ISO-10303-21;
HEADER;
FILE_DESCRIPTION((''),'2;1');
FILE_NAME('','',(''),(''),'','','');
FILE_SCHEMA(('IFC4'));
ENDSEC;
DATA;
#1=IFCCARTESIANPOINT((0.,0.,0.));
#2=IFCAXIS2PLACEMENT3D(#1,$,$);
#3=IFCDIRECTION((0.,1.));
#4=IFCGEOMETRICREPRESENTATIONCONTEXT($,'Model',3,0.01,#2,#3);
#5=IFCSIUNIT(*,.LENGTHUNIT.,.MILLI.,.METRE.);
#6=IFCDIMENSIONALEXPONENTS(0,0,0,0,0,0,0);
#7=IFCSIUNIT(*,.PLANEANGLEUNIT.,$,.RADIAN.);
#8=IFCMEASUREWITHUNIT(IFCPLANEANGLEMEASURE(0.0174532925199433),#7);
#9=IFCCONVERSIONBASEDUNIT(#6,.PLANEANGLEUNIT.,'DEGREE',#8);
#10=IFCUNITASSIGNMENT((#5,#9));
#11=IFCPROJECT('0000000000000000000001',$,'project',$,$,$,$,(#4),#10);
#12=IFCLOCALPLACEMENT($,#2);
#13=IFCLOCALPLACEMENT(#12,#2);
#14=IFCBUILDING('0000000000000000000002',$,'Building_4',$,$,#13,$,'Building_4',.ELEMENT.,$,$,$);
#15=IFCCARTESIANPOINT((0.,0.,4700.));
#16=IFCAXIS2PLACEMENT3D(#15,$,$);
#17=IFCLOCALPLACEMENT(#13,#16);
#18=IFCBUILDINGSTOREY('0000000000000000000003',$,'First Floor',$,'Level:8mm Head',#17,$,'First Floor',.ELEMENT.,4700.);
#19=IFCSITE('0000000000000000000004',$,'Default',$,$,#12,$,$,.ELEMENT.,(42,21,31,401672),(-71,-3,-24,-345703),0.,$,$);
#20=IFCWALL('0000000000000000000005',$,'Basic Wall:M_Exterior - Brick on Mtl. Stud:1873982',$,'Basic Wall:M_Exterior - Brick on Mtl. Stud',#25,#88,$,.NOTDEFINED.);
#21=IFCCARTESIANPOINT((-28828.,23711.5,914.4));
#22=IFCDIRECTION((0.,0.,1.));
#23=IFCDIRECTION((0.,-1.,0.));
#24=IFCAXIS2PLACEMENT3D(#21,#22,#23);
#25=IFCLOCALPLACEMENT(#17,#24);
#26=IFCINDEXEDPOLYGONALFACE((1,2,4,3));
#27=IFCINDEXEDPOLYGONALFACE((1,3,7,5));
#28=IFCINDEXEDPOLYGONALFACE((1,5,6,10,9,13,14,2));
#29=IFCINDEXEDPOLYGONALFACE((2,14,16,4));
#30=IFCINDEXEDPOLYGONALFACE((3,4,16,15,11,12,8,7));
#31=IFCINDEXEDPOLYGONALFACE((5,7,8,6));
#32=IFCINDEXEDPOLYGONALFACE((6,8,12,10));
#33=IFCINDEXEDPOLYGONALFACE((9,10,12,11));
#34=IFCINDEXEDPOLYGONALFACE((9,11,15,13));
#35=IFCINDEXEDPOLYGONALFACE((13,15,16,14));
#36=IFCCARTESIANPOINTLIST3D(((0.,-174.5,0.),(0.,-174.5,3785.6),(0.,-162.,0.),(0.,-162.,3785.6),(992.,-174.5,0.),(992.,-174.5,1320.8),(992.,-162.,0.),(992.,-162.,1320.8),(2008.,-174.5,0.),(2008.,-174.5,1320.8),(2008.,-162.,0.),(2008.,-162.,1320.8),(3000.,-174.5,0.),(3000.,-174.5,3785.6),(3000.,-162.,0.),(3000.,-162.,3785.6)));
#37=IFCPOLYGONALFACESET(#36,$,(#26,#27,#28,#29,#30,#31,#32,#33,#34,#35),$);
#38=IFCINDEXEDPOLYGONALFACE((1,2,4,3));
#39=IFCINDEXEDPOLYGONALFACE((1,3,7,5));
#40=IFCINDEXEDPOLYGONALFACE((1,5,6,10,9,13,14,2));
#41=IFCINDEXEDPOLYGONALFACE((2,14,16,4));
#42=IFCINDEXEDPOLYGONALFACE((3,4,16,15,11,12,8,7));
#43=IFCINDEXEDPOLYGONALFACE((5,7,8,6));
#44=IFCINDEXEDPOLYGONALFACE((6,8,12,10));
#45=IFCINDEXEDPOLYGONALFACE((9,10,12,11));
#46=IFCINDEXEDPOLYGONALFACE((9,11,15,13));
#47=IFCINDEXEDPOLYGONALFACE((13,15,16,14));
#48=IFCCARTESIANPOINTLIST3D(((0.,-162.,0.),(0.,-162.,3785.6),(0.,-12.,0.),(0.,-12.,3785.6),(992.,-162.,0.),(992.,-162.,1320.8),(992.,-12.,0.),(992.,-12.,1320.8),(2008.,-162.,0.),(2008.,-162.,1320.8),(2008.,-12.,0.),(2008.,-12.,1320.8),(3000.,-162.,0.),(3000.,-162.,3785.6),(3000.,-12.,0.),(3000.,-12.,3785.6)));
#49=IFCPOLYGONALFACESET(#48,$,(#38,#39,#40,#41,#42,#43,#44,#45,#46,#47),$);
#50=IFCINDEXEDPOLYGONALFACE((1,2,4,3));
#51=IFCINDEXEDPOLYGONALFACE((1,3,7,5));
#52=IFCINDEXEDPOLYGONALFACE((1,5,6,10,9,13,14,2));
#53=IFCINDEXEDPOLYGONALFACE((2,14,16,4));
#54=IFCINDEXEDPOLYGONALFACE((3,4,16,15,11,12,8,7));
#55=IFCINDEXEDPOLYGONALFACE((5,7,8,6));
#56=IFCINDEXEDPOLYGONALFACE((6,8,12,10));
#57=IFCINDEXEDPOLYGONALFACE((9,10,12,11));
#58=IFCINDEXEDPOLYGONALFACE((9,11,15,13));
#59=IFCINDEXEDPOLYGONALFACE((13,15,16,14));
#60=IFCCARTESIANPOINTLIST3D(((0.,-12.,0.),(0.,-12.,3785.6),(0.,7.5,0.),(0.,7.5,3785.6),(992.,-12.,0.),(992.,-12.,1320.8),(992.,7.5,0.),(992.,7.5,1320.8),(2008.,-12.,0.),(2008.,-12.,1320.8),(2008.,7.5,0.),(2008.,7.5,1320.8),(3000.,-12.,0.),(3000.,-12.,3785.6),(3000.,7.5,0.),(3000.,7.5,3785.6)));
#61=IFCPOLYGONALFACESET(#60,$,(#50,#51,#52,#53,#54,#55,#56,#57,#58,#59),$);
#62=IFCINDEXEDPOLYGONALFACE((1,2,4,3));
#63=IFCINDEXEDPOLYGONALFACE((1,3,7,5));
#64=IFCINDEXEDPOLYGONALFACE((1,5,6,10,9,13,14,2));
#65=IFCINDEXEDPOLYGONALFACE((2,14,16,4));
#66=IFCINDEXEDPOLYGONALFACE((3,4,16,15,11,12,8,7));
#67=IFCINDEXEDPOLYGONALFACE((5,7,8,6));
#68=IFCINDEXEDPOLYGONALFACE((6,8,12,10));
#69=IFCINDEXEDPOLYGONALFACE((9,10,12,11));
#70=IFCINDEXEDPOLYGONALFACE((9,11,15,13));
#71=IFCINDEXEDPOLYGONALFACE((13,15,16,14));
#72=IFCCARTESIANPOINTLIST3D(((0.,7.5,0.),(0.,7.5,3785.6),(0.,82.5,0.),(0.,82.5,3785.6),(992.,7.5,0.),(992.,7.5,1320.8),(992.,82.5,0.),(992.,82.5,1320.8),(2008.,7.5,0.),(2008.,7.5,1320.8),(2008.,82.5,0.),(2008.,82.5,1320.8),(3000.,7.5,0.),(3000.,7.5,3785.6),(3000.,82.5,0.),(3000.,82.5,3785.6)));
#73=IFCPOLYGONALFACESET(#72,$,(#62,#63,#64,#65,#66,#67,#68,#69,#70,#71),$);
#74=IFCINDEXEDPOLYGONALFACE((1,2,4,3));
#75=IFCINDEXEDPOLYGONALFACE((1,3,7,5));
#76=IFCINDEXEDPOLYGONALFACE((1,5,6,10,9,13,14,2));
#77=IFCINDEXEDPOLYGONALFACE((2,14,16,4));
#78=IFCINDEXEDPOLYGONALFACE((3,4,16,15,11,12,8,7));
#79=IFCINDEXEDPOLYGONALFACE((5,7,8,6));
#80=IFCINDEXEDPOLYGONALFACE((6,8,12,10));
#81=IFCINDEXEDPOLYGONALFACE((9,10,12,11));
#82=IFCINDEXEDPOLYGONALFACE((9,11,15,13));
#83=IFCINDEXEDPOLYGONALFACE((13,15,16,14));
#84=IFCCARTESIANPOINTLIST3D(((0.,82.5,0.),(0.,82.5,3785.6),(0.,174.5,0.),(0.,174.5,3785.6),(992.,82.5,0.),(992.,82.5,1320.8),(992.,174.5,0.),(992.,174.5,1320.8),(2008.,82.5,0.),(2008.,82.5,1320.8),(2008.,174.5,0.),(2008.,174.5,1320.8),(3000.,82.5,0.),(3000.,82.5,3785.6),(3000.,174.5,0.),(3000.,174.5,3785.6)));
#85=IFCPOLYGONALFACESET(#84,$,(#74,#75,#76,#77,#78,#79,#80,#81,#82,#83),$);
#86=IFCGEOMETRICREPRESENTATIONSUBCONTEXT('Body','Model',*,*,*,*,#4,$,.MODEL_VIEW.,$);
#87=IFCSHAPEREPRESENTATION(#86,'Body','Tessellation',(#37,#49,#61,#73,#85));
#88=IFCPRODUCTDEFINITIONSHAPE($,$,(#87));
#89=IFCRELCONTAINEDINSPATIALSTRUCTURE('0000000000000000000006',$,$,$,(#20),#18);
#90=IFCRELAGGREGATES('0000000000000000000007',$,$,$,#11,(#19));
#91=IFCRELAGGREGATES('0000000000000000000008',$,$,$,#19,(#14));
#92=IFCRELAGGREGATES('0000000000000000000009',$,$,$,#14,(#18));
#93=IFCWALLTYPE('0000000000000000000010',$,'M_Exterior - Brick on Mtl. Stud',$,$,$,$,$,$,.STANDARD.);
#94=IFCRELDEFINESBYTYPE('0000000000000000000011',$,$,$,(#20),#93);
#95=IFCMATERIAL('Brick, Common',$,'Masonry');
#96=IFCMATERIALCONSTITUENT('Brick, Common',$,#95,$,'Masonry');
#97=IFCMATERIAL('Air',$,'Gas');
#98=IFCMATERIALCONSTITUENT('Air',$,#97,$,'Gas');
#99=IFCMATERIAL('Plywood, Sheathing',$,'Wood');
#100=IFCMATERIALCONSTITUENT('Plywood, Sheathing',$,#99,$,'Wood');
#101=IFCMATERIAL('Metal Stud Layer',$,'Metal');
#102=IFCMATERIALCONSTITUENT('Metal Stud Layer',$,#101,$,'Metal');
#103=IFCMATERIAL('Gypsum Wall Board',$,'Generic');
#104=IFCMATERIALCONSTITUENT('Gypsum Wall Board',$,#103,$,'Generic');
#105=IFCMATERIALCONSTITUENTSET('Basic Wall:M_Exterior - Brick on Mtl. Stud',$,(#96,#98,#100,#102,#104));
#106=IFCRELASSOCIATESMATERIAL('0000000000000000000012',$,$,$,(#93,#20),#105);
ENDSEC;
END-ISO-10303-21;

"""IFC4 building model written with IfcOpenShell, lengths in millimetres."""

from ifc_helpers import new_model, entity, si_unit, converted_unit, direction, frame, origin, place, context, subcontext, project, spatial, indexed_curve, outline, extrude, material, constituent, constituent_set, type_object, element, save


model = new_model("IFC4")

# Units and contexts
model_context = context("Model", 3, precision=0.01, world=origin(), true_north=direction((0.0, 1.0)))
body_context = subcontext(model_context, "Body", "Model", "MODEL_VIEW")
ifc_project = project(units=[si_unit("LENGTHUNIT", "METRE", prefix="MILLI"), converted_unit("PLANEANGLEUNIT", "DEGREE", entity("IfcPlaneAngleMeasure", 0.0174532925199433), si_unit("PLANEANGLEUNIT", "RADIAN"), dimensions=[0, 0, 0, 0, 0, 0, 0])], contexts=[model_context])

# Site, building, storey
site_placement = place(None, origin())
site = spatial("IfcSite", under=ifc_project, at=site_placement, Name="Default", CompositionType="ELEMENT", RefLatitude=(42, 21, 31, 401672), RefLongitude=(-71, -3, -24, -345703), RefElevation=0.0)
building_placement = place(site_placement, origin())
building = spatial("IfcBuilding", under=site, at=building_placement, Name="Building_4", LongName="Building_4", CompositionType="ELEMENT")
storey_placement = place(building_placement, frame((0.0, 0.0, 4700.0)))
storey = spatial("IfcBuildingStorey", under=building, at=storey_placement, Name="First Floor", ObjectType="Level:8mm Head", LongName="First Floor", CompositionType="ELEMENT", Elevation=4700.0)

# Shared definitions
ifc_material_1 = material(Name="Brick, Common", Category="Masonry")
ifc_constituent_1 = constituent(ifc_material_1, Name="Brick, Common", Category="Masonry")
ifc_material_2 = material(Name="Air", Category="Gas")
ifc_constituent_2 = constituent(ifc_material_2, Name="Air", Category="Gas")
ifc_material_3 = material(Name="Plywood, Sheathing", Category="Wood")
ifc_constituent_3 = constituent(ifc_material_3, Name="Plywood, Sheathing", Category="Wood")
ifc_material_4 = material(Name="Metal Stud Layer", Category="Metal")
ifc_constituent_4 = constituent(ifc_material_4, Name="Metal Stud Layer", Category="Metal")
ifc_material_5 = material(Name="Gypsum Wall Board", Category="Generic")
ifc_constituent_5 = constituent(ifc_material_5, Name="Gypsum Wall Board", Category="Generic")
ifc_constituent_set_1 = constituent_set(constituents=[ifc_constituent_1, ifc_constituent_2, ifc_constituent_3, ifc_constituent_4, ifc_constituent_5], Name="Basic Wall:M_Exterior - Brick on Mtl. Stud")
wall_type_1 = type_object("IfcWallType", Name="M_Exterior - Brick on Mtl. Stud", PredefinedType="STANDARD", material=ifc_constituent_set_1)

# Wall, opening
wall_1_placement = place(storey_placement, frame((-28828.0, 23711.5, 914.4), z_axis=(0.0, 0.0, 1.0), x_axis=(0.0, -1.0, 0.0)))
wall_1 = element("IfcWall", 1, at=wall_1_placement, inside=storey, type_object=wall_type_1, material=ifc_constituent_set_1, Name="Basic Wall:M_Exterior - Brick on Mtl. Stud:1873982", ObjectType="Basic Wall:M_Exterior - Brick on Mtl. Stud", PredefinedType="NOTDEFINED", context=body_context, shape_type="SweptSolid", body=[
    extrude(outline(indexed_curve([(-1500.0, -1276.6), (-508.0, -1276.6), (-508.0, 44.2), (508.0, 44.2), (508.0, -1276.6), (1500.0, -1276.6), (1500.0, 2509.0), (-1500.0, 2509.0), (-1500.0, -1276.6)], self_intersect=False)), frame((1500.0, -174.5, 1276.6), z_axis=(0.0, 1.0, 0.0), x_axis=(-1.0, 0.0, 0.0)), (0.0, 0.0, 1.0), 12.5),
    extrude(outline(indexed_curve([(-1276.6, -508.0), (-1276.6, -1500.0), (2509.0, -1500.0), (2509.0, 1500.0), (-1276.6, 1500.0), (-1276.6, 508.0), (44.2, 508.0), (44.2, -508.0), (-1276.6, -508.0)], self_intersect=False)), frame((1500.0, -162.0, 1276.6), z_axis=(0.0, -1.0, 0.0), x_axis=(0.0, 0.0, 1.0)), (0.0, 0.0, -1.0), 150.0),
    extrude(outline(indexed_curve([(-1276.6, -508.0), (-1276.6, -1500.0), (2509.0, -1500.0), (2509.0, 1500.0), (-1276.6, 1500.0), (-1276.6, 508.0), (44.2, 508.0), (44.2, -508.0), (-1276.6, -508.0)], self_intersect=False)), frame((1500.0, -12.0, 1276.6), z_axis=(0.0, -1.0, 0.0), x_axis=(0.0, 0.0, 1.0)), (0.0, 0.0, -1.0), 19.5),
    extrude(outline(indexed_curve([(-1276.6, -508.0), (-1276.6, -1500.0), (2509.0, -1500.0), (2509.0, 1500.0), (-1276.6, 1500.0), (-1276.6, 508.0), (44.2, 508.0), (44.2, -508.0), (-1276.6, -508.0)], self_intersect=False)), frame((1500.0, 7.5, 1276.6), z_axis=(0.0, -1.0, 0.0), x_axis=(0.0, 0.0, 1.0)), (0.0, 0.0, -1.0), 75.0),
    extrude(outline(indexed_curve([(-1276.6, -508.0), (-1276.6, -1500.0), (2509.0, -1500.0), (2509.0, 1500.0), (-1276.6, 1500.0), (-1276.6, 508.0), (44.2, 508.0), (44.2, -508.0), (-1276.6, -508.0)], self_intersect=False)), frame((1500.0, 82.5, 1276.6), z_axis=(0.0, -1.0, 0.0), x_axis=(0.0, 0.0, 1.0)), (0.0, 0.0, -1.0), 92.0),
])
opening_1_placement = place(wall_1_placement, frame((992.0, -174.5, -914.4)))
element("IfcOpeningElement", 2, at=opening_1_placement, cuts=wall_1, PredefinedType="OPENING", context=body_context, shape_type="SweptSolid", body=[
    extrude(outline(indexed_curve([(0.0, 1016.0), (0.0, 0.0), (2235.2, 0.0), (2235.2, 1016.0), (0.0, 1016.0)], self_intersect=False)), frame((0.0, 0.0, 0.0), z_axis=(0.0, 1.0, 0.0), x_axis=(0.0, 0.0, 1.0)), (0.0, 0.0, 1.0), 349.0),
])

save(model, "model.ifc")
